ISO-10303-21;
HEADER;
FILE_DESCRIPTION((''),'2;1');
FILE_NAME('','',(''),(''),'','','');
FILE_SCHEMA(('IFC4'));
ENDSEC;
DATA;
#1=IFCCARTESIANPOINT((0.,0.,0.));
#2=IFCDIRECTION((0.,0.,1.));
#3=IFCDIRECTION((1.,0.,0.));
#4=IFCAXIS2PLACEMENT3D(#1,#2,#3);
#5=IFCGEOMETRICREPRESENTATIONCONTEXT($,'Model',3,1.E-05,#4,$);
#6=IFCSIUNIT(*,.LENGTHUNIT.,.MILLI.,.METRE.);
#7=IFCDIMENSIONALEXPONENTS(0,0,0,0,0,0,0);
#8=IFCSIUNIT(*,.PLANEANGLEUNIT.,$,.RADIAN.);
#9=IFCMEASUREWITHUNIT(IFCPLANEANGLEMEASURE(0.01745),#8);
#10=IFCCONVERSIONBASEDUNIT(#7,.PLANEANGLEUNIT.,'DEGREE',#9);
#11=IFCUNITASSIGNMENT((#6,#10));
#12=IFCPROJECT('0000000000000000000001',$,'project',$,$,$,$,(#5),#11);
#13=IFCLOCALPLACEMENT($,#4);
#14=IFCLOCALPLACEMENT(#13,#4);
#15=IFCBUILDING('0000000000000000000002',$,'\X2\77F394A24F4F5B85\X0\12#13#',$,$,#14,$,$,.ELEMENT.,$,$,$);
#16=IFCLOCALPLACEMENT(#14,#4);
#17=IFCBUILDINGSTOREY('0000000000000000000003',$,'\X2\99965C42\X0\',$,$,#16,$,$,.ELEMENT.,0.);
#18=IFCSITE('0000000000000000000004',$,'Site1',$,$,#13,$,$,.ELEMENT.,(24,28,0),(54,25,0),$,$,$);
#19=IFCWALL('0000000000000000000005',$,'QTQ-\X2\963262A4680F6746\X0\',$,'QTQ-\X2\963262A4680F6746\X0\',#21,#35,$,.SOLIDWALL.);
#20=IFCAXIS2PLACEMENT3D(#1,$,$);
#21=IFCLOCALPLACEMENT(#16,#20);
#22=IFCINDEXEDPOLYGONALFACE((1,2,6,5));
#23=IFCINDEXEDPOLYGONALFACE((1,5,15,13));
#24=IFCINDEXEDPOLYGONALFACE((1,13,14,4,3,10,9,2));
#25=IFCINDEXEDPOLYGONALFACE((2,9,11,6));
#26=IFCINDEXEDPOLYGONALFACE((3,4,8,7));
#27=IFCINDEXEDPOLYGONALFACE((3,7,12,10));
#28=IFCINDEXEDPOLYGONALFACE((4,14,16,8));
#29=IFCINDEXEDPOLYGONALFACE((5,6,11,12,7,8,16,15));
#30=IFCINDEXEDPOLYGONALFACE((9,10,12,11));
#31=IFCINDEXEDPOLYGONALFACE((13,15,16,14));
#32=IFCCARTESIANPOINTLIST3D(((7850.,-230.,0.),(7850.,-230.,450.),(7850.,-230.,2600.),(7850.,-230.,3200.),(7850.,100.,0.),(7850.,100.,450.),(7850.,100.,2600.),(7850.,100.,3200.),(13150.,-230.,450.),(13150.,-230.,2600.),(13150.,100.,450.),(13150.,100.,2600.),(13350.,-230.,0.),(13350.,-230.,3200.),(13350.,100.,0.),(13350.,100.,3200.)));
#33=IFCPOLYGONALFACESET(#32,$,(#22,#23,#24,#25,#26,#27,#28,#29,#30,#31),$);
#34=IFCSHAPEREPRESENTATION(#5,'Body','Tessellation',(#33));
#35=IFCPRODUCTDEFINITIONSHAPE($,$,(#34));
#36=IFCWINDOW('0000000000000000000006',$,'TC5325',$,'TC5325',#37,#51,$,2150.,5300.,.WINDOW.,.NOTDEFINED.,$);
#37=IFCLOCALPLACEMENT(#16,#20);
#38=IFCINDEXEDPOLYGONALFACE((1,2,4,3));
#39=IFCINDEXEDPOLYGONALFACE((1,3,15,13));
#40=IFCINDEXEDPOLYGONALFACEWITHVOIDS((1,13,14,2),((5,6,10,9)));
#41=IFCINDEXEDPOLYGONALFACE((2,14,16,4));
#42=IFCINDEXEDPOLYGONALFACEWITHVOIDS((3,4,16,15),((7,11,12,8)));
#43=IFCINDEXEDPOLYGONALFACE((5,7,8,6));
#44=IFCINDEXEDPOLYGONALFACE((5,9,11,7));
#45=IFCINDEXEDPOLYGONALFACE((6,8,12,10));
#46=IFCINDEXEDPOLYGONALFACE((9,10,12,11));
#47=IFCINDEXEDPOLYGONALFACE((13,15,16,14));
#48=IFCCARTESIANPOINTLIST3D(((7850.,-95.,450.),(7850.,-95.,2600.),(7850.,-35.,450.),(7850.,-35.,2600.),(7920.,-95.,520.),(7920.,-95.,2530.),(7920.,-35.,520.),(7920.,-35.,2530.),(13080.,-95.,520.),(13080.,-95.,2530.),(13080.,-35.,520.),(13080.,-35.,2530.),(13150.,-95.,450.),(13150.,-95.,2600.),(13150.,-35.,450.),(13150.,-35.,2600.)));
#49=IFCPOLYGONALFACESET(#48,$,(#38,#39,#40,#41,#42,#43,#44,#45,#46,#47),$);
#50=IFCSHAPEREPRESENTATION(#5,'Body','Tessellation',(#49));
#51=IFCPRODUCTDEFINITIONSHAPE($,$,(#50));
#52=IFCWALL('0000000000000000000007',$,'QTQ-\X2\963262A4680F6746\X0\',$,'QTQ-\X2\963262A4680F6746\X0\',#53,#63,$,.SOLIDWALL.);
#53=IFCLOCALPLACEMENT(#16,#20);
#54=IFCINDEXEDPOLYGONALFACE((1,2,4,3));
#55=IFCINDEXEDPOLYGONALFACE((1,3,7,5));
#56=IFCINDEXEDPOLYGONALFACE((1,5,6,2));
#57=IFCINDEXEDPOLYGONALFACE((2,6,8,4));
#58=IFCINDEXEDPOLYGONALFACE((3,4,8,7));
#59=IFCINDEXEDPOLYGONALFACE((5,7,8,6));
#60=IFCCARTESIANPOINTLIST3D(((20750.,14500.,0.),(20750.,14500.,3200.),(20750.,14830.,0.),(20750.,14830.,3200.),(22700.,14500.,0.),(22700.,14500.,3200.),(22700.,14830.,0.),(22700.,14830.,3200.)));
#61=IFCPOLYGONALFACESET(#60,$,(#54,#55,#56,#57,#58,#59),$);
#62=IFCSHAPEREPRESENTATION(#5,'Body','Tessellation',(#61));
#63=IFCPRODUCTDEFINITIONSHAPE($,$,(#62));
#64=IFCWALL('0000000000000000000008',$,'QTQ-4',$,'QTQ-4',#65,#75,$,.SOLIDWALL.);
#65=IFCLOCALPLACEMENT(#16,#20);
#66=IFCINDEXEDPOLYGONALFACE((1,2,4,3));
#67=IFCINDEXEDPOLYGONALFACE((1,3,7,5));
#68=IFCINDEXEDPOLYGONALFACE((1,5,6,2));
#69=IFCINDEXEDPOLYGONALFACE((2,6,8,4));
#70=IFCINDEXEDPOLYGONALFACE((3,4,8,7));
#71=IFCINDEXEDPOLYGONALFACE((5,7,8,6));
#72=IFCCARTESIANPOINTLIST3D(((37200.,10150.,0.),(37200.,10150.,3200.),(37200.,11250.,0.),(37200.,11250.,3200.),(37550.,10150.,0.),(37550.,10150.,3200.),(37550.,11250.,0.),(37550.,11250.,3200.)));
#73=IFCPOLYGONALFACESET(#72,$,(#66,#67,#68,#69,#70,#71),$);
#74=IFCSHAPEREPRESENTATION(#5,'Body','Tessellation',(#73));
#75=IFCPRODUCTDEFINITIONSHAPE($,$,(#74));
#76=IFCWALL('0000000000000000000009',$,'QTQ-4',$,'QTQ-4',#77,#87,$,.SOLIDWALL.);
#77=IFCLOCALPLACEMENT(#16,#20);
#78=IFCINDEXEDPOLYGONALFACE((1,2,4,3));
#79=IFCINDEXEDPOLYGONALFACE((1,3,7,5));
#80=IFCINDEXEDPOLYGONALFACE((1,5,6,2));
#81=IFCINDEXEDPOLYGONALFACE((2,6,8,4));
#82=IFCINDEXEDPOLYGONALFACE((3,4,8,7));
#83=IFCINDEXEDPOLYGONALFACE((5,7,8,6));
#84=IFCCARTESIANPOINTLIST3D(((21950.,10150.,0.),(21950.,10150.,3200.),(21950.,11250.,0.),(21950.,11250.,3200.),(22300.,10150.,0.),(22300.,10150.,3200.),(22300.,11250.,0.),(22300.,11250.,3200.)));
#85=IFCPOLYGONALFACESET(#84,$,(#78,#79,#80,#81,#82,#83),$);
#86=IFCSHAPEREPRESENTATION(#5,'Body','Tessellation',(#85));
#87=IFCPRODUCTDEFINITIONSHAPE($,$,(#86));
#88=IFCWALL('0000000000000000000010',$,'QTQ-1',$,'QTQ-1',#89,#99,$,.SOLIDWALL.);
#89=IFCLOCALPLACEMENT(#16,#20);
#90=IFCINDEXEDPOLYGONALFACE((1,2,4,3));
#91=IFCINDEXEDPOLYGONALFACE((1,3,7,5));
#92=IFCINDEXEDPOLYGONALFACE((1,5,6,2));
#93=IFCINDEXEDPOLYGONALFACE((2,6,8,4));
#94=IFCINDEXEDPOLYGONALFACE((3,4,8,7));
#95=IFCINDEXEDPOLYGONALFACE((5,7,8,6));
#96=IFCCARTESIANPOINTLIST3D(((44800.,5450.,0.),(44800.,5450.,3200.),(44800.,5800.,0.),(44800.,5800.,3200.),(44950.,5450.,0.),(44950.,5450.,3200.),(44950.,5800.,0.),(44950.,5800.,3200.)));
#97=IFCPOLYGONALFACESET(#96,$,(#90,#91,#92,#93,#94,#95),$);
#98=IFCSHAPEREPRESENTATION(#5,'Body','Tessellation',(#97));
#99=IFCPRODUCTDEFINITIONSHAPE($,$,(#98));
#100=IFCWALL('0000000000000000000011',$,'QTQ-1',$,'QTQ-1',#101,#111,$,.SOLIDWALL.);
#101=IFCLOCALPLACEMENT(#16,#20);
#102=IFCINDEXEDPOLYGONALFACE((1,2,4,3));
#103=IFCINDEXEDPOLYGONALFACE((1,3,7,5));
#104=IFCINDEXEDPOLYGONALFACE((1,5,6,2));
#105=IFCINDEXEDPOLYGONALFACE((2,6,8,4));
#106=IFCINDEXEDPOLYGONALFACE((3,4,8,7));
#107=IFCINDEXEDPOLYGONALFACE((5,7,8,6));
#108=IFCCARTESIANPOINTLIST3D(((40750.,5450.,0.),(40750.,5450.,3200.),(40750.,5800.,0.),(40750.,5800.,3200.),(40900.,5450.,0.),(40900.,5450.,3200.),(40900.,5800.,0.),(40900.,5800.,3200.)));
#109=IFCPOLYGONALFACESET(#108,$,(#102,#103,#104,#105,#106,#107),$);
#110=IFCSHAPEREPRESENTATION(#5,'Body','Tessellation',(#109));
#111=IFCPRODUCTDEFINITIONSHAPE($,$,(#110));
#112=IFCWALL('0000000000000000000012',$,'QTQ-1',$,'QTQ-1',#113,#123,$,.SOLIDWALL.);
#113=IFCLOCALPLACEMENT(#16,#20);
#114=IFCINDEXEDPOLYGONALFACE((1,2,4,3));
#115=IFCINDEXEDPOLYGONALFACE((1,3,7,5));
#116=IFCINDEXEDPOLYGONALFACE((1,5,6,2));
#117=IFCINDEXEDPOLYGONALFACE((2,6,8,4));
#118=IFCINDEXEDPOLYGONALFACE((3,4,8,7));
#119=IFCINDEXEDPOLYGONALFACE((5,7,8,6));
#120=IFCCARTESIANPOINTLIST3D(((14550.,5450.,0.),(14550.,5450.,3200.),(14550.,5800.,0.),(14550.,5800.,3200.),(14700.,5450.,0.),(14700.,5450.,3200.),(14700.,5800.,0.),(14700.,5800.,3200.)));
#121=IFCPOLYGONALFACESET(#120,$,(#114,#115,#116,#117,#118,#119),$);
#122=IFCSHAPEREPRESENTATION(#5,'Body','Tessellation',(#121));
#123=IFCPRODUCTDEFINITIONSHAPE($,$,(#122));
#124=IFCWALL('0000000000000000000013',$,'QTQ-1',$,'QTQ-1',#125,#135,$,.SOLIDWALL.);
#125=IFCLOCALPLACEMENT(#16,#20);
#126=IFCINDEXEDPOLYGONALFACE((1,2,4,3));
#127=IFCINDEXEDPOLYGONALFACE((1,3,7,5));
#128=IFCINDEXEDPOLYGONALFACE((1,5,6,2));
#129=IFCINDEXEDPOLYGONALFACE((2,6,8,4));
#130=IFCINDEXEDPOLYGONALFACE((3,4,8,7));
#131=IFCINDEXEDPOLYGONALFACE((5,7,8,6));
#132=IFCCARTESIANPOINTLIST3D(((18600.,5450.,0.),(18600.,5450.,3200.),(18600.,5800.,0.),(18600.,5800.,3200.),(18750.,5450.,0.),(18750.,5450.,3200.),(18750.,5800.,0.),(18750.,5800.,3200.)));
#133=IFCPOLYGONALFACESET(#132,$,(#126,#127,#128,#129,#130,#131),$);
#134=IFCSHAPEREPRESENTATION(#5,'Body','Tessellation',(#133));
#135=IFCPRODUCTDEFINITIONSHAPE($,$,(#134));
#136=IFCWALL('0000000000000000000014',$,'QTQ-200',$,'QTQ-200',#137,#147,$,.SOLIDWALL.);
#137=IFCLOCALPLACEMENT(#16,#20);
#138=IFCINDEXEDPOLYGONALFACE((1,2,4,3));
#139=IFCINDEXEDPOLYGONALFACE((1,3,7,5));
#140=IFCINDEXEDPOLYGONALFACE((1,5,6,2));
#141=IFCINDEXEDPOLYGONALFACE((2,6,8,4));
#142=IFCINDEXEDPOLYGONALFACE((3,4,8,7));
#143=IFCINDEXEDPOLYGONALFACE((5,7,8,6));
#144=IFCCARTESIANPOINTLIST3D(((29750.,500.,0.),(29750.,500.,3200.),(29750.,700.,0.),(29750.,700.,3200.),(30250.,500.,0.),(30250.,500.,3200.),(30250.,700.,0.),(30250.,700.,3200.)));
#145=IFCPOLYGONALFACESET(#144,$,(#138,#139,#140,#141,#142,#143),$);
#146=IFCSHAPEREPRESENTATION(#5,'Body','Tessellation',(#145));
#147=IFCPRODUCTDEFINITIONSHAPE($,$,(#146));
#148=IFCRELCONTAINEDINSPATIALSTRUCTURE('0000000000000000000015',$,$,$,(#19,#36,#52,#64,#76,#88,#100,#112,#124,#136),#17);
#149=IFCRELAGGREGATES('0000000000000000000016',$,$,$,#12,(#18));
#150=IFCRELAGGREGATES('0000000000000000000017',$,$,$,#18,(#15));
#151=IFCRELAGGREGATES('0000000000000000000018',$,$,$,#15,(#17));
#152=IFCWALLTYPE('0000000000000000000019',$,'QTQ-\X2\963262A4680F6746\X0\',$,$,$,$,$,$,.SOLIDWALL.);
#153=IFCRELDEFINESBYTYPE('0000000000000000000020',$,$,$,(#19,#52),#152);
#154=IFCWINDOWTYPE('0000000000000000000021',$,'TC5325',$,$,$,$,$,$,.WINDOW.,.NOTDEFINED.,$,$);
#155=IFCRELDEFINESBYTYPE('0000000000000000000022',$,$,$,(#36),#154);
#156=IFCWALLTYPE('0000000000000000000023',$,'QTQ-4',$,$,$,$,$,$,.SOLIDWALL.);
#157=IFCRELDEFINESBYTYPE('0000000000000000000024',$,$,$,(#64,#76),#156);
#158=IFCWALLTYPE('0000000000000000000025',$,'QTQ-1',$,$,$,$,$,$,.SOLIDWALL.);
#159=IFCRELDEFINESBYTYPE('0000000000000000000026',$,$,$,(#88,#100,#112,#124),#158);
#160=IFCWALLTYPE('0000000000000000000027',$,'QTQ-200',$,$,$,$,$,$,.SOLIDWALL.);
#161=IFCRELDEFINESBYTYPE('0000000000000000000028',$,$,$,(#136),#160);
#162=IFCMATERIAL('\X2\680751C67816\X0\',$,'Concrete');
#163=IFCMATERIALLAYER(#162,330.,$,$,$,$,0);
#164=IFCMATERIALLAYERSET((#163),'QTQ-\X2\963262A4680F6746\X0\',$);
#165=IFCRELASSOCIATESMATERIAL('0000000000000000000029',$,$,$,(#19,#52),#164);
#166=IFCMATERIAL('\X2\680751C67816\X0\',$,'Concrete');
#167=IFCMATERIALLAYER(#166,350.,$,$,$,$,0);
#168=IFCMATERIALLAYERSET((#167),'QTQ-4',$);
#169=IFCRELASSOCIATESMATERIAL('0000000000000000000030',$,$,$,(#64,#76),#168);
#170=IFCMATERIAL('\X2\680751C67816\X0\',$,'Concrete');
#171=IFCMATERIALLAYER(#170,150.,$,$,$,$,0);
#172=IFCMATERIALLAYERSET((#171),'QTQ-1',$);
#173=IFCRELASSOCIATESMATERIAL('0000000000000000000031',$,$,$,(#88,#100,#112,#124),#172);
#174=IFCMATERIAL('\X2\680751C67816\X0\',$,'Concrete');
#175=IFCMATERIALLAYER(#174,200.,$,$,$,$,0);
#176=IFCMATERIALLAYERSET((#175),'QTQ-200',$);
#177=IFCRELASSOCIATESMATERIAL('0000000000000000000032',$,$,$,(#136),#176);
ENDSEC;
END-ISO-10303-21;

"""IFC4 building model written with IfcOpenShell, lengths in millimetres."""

from ifc_helpers import new_model, entity, si_unit, converted_unit, frame, origin_with_axes, place, context, project, spatial, polyline, outline, extrude, material, layer, layer_set, type_object, element, fill, save


model = new_model("IFC4")

# Units and contexts
model_context = context("Model", 3, precision=1e-05, world=origin_with_axes())
ifc_project = project(units=[si_unit("LENGTHUNIT", "METRE", prefix="MILLI"), converted_unit("PLANEANGLEUNIT", "DEGREE", entity("IfcPlaneAngleMeasure", 0.01745), si_unit("PLANEANGLEUNIT", "RADIAN"), dimensions=[0, 0, 0, 0, 0, 0, 0])], contexts=[model_context])

# Site, building, storey
site_placement = place(None, origin_with_axes())
site = spatial("IfcSite", under=ifc_project, at=site_placement, Name="Site1", CompositionType="ELEMENT", RefLatitude=(24, 28, 0), RefLongitude=(54, 25, 0))
building_placement = place(site_placement, origin_with_axes())
building = spatial("IfcBuilding", under=site, at=building_placement, Name="石钢住宅12#13#", CompositionType="ELEMENT")
storey_placement = place(building_placement, origin_with_axes())
storey = spatial("IfcBuildingStorey", under=building, at=storey_placement, Name="首层", CompositionType="ELEMENT", Elevation=0.0)

# Shared definitions
ifc_material_1 = material(Name="标准砖", Category="Concrete")
ifc_layer_1 = layer(ifc_material_1, 330.0, Priority=0)
ifc_layer_set_1 = layer_set([ifc_layer_1], Name="QTQ-防护栏杆")
wall_type_1 = type_object("IfcWallType", Name="QTQ-防护栏杆", PredefinedType="SOLIDWALL")

# Wall, opening, window
wall_1_placement = place(storey_placement, origin_with_axes())
wall_1 = element("IfcWall", 1, at=wall_1_placement, inside=storey, type_object=wall_type_1, material=ifc_layer_set_1, Name="QTQ-防护栏杆", ObjectType="QTQ-防护栏杆", PredefinedType="SOLIDWALL", context=model_context, shape_type="SweptSolid", body=[
    extrude(outline(polyline([(0.0, 0.0), (3200.0, 0.0), (3200.0, 5500.0), (0.0, 5500.0), (0.0, 0.0)])), frame((7850.0, 100.0, 3200.0), z_axis=(0.0, -1.0, 0.0), x_axis=(0.0, 0.0, -1.0)), (0.0, 0.0, 1.0), 330.0),
])
opening_1_placement = place(storey_placement, origin_with_axes())
opening_1 = element("IfcOpeningElement", 2, at=opening_1_placement, cuts=wall_1, PredefinedType="OPENING", context=model_context, shape_type="SweptSolid", body=[
    extrude(outline(polyline([(0.0, 0.0), (5300.0, 0.0), (5300.0, 2150.0), (0.0, 2150.0), (0.0, 0.0)])), frame((7850.0, 1100.0, 450.0), z_axis=(0.0, -1.0, 0.0), x_axis=(1.0, 0.0, 0.0)), (0.0, 0.0, 1.0), 2330.0),
])
window_type_1 = type_object("IfcWindowType", Name="TC5325", PartitioningType="NOTDEFINED", PredefinedType="WINDOW")
window_1_placement = place(storey_placement, origin_with_axes())
window_1 = element("IfcWindow", 3, at=window_1_placement, inside=storey, type_object=window_type_1, Name="TC5325", ObjectType="TC5325", OverallHeight=2150.0, OverallWidth=5300.0, PartitioningType="NOTDEFINED", PredefinedType="WINDOW", context=model_context, shape_type="SweptSolid", body=[
    extrude(outline(polyline([(-2650.0, -1075.0), (2650.0, -1075.0), (2650.0, 1075.0), (-2650.0, 1075.0), (-2650.0, -1075.0)]), holes=[polyline([(-2580.0, -1005.0), (-2580.0, 1005.0), (2580.0, 1005.0), (2580.0, -1005.0), (-2580.0, -1005.0)])]), frame((10500.0, -35.0, 1525.0), z_axis=(0.0, -1.0, 0.0), x_axis=(1.0, 0.0, 0.0)), (0.0, 0.0, 1.0), 60.0),
])
fill(opening_1, window_1)

# Walls
wall_2_placement = place(storey_placement, origin_with_axes())
element("IfcWall", 4, at=wall_2_placement, inside=storey, type_object=wall_type_1, material=ifc_layer_set_1, Name="QTQ-防护栏杆", ObjectType="QTQ-防护栏杆", PredefinedType="SOLIDWALL", context=model_context, shape_type="SweptSolid", body=[
    extrude(outline(polyline([(0.0, 0.0), (3200.0, 0.0), (3200.0, 1950.0), (0.0, 1950.0), (0.0, 0.0)])), frame((20750.0, 14830.0, 3200.0), z_axis=(0.0, -1.0, 0.0), x_axis=(0.0, 0.0, -1.0)), (0.0, 0.0, 1.0), 330.0),
])
ifc_material_2 = material(Name="标准砖", Category="Concrete")
ifc_layer_2 = layer(ifc_material_2, 350.0, Priority=0)
ifc_layer_set_2 = layer_set([ifc_layer_2], Name="QTQ-4")
wall_type_2 = type_object("IfcWallType", Name="QTQ-4", PredefinedType="SOLIDWALL")
wall_3_placement = place(storey_placement, origin_with_axes())
element("IfcWall", 5, at=wall_3_placement, inside=storey, type_object=wall_type_2, material=ifc_layer_set_2, Name="QTQ-4", ObjectType="QTQ-4", PredefinedType="SOLIDWALL", context=model_context, shape_type="SweptSolid", body=[
    extrude(outline(polyline([(0.0, 0.0), (3200.0, 0.0), (3200.0, 1100.0), (0.0, 1100.0), (0.0, 0.0)])), frame((37550.0, 11250.0, 3200.0), z_axis=(-1.0, 0.0, 0.0), x_axis=(0.0, 0.0, -1.0)), (0.0, 0.0, 1.0), 350.0),
])
wall_4_placement = place(storey_placement, origin_with_axes())
element("IfcWall", 6, at=wall_4_placement, inside=storey, type_object=wall_type_2, material=ifc_layer_set_2, Name="QTQ-4", ObjectType="QTQ-4", PredefinedType="SOLIDWALL", context=model_context, shape_type="SweptSolid", body=[
    extrude(outline(polyline([(0.0, 0.0), (3200.0, 0.0), (3200.0, 1100.0), (0.0, 1100.0), (0.0, 0.0)])), frame((22300.0, 11250.0, 3200.0), z_axis=(-1.0, 0.0, 0.0), x_axis=(0.0, 0.0, -1.0)), (0.0, 0.0, 1.0), 350.0),
])
ifc_material_3 = material(Name="标准砖", Category="Concrete")
ifc_layer_3 = layer(ifc_material_3, 150.0, Priority=0)
ifc_layer_set_3 = layer_set([ifc_layer_3], Name="QTQ-1")
wall_type_3 = type_object("IfcWallType", Name="QTQ-1", PredefinedType="SOLIDWALL")
wall_5_placement = place(storey_placement, origin_with_axes())
element("IfcWall", 7, at=wall_5_placement, inside=storey, type_object=wall_type_3, material=ifc_layer_set_3, Name="QTQ-1", ObjectType="QTQ-1", PredefinedType="SOLIDWALL", context=model_context, shape_type="SweptSolid", body=[
    extrude(outline(polyline([(0.0, 0.0), (3200.0, 0.0), (3200.0, 350.0), (0.0, 350.0), (0.0, 0.0)])), frame((44800.0, 5450.0, 3200.0), z_axis=(1.0, 0.0, 0.0), x_axis=(0.0, 0.0, -1.0)), (0.0, 0.0, 1.0), 150.0),
])
wall_6_placement = place(storey_placement, origin_with_axes())
element("IfcWall", 8, at=wall_6_placement, inside=storey, type_object=wall_type_3, material=ifc_layer_set_3, Name="QTQ-1", ObjectType="QTQ-1", PredefinedType="SOLIDWALL", context=model_context, shape_type="SweptSolid", body=[
    extrude(outline(polyline([(0.0, 0.0), (3200.0, 0.0), (3200.0, 350.0), (0.0, 350.0), (0.0, 0.0)])), frame((40750.0, 5450.0, 3200.0), z_axis=(1.0, 0.0, 0.0), x_axis=(0.0, 0.0, -1.0)), (0.0, 0.0, 1.0), 150.0),
])
wall_7_placement = place(storey_placement, origin_with_axes())
element("IfcWall", 9, at=wall_7_placement, inside=storey, type_object=wall_type_3, material=ifc_layer_set_3, Name="QTQ-1", ObjectType="QTQ-1", PredefinedType="SOLIDWALL", context=model_context, shape_type="SweptSolid", body=[
    extrude(outline(polyline([(0.0, 0.0), (3200.0, 0.0), (3200.0, 350.0), (0.0, 350.0), (0.0, 0.0)])), frame((14550.0, 5450.0, 3200.0), z_axis=(1.0, 0.0, 0.0), x_axis=(0.0, 0.0, -1.0)), (0.0, 0.0, 1.0), 150.0),
])
wall_8_placement = place(storey_placement, origin_with_axes())
element("IfcWall", 10, at=wall_8_placement, inside=storey, type_object=wall_type_3, material=ifc_layer_set_3, Name="QTQ-1", ObjectType="QTQ-1", PredefinedType="SOLIDWALL", context=model_context, shape_type="SweptSolid", body=[
    extrude(outline(polyline([(0.0, 0.0), (3200.0, 0.0), (3200.0, 350.0), (0.0, 350.0), (0.0, 0.0)])), frame((18600.0, 5450.0, 3200.0), z_axis=(1.0, 0.0, 0.0), x_axis=(0.0, 0.0, -1.0)), (0.0, 0.0, 1.0), 150.0),
])
ifc_material_4 = material(Name="标准砖", Category="Concrete")
ifc_layer_4 = layer(ifc_material_4, 200.0, Priority=0)
ifc_layer_set_4 = layer_set([ifc_layer_4], Name="QTQ-200")
wall_type_4 = type_object("IfcWallType", Name="QTQ-200", PredefinedType="SOLIDWALL")
wall_9_placement = place(storey_placement, origin_with_axes())
element("IfcWall", 11, at=wall_9_placement, inside=storey, type_object=wall_type_4, material=ifc_layer_set_4, Name="QTQ-200", ObjectType="QTQ-200", PredefinedType="SOLIDWALL", context=model_context, shape_type="SweptSolid", body=[
    extrude(outline(polyline([(0.0, 0.0), (3200.0, 0.0), (3200.0, 500.0), (0.0, 500.0), (0.0, 0.0)])), frame((30250.0, 500.0, 3200.0), z_axis=(0.0, 1.0, 0.0), x_axis=(0.0, 0.0, -1.0)), (0.0, 0.0, 1.0), 200.0),
])

save(model, "model.ifc")
